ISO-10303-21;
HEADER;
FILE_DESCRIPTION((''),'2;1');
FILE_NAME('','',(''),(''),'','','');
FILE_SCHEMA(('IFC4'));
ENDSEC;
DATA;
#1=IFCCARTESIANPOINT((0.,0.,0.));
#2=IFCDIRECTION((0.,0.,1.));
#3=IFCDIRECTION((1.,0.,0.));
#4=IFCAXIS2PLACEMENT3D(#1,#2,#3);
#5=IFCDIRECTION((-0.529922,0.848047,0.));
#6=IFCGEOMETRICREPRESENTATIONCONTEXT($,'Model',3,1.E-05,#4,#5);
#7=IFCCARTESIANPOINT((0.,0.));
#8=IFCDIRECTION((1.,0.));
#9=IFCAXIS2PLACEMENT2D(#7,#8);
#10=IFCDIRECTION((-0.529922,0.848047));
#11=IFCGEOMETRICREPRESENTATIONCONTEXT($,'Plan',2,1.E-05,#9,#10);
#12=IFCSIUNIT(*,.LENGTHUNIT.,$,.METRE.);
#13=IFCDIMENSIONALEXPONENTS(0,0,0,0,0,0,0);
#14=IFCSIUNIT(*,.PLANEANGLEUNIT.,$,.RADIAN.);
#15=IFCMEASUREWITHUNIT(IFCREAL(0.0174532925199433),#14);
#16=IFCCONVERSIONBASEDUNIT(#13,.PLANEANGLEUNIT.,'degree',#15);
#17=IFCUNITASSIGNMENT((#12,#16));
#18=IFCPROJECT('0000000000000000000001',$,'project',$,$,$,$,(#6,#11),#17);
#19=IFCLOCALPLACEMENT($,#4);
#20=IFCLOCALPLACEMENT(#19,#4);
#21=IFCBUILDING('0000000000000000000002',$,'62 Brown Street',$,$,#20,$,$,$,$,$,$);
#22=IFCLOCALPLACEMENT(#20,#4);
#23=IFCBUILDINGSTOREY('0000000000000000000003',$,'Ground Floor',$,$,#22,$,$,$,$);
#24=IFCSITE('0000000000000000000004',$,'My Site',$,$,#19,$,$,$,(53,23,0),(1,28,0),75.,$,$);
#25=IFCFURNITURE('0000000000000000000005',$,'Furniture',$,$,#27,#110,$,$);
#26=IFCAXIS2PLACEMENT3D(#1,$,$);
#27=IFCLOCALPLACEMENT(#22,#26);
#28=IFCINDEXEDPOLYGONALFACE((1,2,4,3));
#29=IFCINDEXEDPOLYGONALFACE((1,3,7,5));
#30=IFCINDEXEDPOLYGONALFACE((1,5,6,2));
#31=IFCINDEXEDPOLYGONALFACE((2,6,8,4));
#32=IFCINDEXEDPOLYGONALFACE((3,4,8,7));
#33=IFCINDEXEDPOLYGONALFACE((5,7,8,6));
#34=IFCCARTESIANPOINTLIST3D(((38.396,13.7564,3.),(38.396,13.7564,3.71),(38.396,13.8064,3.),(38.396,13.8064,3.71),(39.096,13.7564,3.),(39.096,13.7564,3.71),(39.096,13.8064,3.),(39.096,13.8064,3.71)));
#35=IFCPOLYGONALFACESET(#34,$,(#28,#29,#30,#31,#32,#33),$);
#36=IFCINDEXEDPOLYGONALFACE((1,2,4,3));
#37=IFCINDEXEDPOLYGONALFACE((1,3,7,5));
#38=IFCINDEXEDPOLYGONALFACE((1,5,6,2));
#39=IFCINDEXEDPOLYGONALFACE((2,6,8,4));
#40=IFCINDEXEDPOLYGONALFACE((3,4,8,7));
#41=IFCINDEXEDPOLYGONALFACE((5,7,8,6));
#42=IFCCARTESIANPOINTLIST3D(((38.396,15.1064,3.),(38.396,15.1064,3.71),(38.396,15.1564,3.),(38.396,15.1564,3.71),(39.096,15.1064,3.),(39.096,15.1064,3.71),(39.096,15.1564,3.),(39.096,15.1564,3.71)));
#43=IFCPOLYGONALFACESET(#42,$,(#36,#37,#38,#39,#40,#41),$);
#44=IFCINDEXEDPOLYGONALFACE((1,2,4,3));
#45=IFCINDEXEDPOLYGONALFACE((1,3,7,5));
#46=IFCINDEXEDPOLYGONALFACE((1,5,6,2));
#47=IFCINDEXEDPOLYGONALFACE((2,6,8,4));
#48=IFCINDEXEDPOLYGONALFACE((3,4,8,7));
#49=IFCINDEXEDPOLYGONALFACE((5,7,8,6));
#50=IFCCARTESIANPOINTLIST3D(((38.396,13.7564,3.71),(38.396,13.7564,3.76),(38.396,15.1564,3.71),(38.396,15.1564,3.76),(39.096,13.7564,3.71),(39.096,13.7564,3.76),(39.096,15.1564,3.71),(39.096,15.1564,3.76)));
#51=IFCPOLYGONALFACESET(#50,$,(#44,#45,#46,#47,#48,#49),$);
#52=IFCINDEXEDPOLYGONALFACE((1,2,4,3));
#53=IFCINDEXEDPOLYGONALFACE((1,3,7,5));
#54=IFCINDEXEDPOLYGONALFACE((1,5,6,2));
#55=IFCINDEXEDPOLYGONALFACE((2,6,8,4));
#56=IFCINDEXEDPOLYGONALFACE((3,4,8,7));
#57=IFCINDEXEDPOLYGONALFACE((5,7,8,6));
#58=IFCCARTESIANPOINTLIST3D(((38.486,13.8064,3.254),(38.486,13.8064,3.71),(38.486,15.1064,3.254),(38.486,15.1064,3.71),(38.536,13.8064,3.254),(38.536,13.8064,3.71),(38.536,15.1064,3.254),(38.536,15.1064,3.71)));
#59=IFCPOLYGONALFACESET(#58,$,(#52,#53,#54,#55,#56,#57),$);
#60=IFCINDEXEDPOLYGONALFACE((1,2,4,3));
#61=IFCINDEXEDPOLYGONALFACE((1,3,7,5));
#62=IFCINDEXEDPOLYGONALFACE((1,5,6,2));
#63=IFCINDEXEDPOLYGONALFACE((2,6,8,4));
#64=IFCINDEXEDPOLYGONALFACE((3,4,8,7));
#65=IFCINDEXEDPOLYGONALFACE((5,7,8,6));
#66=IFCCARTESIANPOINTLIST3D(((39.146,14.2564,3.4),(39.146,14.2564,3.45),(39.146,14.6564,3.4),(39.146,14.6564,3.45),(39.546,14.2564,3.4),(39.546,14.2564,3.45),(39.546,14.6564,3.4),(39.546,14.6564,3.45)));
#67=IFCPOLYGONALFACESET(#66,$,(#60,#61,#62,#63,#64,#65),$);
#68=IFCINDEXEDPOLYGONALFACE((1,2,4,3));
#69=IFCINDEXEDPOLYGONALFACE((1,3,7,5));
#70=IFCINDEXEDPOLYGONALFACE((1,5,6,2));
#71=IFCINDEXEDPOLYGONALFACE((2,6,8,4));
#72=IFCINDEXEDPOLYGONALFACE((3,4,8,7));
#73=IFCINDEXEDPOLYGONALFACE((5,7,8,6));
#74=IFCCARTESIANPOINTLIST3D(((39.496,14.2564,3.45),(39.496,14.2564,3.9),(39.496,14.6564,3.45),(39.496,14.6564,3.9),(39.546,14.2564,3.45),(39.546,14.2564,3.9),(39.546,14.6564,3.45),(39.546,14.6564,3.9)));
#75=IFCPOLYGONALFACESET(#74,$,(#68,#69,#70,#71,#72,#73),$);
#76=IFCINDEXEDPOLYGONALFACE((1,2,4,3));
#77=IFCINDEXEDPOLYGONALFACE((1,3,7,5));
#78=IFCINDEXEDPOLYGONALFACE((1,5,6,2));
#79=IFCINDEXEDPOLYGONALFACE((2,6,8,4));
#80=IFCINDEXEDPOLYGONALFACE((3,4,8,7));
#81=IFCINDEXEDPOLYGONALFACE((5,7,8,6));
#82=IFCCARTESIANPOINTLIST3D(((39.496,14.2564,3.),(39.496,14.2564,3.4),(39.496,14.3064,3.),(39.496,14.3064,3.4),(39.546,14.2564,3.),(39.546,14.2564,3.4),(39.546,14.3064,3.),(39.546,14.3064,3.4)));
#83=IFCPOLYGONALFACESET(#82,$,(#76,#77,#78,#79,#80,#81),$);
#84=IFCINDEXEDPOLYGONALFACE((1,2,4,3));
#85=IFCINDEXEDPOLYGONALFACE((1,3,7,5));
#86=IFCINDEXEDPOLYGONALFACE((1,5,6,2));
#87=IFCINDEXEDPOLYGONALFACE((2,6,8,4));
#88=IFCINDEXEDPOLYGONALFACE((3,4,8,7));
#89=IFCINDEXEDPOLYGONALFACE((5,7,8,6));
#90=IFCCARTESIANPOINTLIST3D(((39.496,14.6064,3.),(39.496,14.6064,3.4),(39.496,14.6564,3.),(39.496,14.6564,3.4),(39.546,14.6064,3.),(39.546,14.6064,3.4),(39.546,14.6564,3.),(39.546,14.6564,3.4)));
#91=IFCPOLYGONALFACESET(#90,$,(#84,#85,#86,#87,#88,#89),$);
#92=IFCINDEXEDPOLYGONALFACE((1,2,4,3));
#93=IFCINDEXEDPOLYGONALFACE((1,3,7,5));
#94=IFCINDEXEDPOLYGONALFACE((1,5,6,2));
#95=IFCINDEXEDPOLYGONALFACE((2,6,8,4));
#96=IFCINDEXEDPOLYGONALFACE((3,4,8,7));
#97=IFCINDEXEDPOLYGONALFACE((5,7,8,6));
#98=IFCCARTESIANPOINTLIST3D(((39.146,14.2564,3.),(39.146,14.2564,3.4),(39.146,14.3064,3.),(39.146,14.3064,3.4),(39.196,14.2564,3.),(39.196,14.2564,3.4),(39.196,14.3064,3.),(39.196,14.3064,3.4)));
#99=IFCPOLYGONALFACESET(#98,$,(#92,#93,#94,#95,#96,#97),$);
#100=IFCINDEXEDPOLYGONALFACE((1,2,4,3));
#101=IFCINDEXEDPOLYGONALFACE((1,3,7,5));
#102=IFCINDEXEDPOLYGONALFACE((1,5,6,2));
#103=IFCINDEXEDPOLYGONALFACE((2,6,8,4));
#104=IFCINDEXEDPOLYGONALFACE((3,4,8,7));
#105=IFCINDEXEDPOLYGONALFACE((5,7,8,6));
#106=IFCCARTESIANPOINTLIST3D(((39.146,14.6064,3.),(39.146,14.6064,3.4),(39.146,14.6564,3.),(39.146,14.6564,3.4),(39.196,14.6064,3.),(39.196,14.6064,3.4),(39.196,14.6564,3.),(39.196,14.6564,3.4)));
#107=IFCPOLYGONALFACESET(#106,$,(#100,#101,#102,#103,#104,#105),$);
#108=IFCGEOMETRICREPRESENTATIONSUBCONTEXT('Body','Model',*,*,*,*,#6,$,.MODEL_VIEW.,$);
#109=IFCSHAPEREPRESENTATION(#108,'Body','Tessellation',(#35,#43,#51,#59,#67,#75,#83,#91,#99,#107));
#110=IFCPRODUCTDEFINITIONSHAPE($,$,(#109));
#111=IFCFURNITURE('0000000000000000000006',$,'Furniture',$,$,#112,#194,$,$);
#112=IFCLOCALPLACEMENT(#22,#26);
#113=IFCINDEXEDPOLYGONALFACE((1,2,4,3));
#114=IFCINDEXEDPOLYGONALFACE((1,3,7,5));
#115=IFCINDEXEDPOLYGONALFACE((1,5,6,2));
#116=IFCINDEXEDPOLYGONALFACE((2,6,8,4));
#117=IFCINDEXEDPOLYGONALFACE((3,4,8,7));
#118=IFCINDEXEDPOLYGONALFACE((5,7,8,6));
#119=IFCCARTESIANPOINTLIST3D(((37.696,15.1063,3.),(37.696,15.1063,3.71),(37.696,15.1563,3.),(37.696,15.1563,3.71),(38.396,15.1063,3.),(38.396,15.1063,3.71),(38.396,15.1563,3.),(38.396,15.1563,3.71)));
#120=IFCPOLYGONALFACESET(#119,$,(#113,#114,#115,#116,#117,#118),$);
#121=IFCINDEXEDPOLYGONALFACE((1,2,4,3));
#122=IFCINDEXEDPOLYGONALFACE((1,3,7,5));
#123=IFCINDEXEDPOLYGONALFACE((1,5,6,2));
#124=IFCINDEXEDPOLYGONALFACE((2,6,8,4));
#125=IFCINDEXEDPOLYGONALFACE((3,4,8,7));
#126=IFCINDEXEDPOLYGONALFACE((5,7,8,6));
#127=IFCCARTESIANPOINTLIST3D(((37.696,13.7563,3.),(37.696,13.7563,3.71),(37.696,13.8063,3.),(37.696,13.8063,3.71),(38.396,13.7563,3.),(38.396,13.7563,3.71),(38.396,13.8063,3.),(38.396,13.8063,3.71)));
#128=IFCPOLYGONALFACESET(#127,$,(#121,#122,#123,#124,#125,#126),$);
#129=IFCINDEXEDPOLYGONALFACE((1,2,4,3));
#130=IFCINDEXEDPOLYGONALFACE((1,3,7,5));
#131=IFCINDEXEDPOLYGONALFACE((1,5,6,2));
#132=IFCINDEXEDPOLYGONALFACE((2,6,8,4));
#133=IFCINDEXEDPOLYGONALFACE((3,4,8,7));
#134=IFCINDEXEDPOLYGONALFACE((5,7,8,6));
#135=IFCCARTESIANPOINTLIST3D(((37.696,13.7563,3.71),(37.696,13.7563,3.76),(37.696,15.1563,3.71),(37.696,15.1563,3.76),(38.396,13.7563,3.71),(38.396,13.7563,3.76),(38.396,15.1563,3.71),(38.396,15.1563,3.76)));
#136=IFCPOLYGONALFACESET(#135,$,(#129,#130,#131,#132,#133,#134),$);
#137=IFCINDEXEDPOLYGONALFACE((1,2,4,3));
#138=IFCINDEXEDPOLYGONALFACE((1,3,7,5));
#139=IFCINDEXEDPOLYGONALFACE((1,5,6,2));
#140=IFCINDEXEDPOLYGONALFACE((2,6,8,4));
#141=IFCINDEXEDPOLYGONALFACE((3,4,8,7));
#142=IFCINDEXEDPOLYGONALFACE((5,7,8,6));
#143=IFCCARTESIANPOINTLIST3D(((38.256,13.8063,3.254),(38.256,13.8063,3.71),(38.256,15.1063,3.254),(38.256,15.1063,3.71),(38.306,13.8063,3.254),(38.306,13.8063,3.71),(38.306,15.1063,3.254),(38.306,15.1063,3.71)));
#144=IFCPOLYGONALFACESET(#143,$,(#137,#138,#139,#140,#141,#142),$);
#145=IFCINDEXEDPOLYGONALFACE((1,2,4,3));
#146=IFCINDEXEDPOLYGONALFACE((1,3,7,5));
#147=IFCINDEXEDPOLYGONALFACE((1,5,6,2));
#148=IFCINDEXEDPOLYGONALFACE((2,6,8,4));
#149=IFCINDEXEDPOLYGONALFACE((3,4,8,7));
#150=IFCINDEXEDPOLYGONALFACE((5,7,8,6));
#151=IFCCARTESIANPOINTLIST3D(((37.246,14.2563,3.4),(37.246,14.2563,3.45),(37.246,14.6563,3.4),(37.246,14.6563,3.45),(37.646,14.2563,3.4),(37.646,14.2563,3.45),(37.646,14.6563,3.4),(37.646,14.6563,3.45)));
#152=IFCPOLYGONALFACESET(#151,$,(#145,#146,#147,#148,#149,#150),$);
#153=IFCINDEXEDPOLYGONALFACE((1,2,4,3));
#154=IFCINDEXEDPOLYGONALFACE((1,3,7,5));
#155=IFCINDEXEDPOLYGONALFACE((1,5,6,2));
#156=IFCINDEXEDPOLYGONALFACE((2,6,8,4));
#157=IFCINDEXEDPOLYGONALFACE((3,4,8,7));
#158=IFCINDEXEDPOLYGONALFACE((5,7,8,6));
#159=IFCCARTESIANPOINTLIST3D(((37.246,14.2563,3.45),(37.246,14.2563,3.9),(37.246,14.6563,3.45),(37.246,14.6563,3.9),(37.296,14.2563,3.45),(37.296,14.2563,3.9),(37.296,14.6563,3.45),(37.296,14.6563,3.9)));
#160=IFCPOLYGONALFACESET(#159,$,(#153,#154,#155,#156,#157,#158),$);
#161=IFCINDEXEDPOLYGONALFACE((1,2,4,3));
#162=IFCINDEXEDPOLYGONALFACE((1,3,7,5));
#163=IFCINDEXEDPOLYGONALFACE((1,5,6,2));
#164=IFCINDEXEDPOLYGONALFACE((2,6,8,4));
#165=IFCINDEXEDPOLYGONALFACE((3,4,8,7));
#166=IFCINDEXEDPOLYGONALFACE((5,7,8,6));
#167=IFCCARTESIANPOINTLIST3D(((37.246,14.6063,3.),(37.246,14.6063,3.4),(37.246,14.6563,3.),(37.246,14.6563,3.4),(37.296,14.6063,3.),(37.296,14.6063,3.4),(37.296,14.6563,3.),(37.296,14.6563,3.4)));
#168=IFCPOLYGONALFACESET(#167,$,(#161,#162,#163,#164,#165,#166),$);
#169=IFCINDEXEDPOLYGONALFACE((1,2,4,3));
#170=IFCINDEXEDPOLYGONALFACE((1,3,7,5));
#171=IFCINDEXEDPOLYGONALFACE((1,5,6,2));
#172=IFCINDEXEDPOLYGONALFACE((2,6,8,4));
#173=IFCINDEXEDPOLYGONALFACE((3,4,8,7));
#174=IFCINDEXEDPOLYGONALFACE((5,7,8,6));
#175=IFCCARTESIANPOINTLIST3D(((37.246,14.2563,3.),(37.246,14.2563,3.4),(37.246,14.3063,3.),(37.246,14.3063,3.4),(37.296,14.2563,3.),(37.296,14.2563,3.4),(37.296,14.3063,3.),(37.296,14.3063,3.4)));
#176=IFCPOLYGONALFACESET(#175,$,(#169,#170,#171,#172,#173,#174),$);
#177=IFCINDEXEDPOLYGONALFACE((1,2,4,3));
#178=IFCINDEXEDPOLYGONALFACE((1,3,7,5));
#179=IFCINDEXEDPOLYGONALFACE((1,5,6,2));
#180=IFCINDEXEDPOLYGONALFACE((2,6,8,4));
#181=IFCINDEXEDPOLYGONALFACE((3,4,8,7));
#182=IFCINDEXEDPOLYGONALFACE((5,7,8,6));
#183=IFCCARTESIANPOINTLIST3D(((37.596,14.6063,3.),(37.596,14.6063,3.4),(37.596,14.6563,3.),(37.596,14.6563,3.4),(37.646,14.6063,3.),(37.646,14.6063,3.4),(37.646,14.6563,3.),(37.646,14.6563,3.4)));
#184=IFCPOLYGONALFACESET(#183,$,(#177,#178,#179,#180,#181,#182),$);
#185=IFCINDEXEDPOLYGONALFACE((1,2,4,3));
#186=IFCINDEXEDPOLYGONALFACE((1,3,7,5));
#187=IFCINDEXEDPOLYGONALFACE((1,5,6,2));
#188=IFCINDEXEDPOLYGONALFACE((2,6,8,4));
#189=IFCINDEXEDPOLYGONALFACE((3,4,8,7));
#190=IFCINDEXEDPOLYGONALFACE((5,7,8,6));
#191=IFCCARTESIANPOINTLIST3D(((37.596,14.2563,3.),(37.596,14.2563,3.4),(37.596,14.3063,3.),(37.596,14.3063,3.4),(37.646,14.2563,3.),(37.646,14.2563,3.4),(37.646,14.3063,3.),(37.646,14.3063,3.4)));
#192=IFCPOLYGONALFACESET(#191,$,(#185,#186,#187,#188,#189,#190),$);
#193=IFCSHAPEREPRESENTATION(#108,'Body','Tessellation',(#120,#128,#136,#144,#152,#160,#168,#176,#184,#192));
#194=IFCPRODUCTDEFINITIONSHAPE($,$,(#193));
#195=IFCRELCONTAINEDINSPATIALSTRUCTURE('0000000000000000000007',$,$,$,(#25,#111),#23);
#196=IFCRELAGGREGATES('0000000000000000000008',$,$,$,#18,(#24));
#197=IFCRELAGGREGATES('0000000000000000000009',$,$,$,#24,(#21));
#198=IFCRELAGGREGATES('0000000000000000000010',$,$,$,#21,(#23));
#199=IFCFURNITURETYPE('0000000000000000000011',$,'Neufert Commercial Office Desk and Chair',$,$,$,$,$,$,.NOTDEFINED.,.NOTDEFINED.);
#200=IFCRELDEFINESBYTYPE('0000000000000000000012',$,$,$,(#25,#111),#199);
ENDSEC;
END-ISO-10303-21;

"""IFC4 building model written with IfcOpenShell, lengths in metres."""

from ifc_helpers import new_model, entity, si_unit, converted_unit, direction, frame, origin_with_axes, origin_2d_with_axis, place, context, subcontext, project, spatial, line, indexed_curve, outline, extrude, shape, source, transform, mapped, type_object, type_shapes, element, save


model = new_model("IFC4")

# Units and contexts
model_context = context("Model", 3, precision=1e-05, world=origin_with_axes(), true_north=direction((-0.529922, 0.848047, 0.0)))
plan_context = context("Plan", 2, precision=1e-05, world=origin_2d_with_axis(), true_north=direction((-0.529922, 0.848047)))
body_context_1 = subcontext(model_context, "Body", "Model", "MODEL_VIEW")
body_context_2 = subcontext(plan_context, "Body", "Plan", "PLAN_VIEW")
ifc_project = project(units=[si_unit("LENGTHUNIT", "METRE"), converted_unit("PLANEANGLEUNIT", "degree", entity("IfcReal", 0.0174532925199433), si_unit("PLANEANGLEUNIT", "RADIAN"), dimensions=[0, 0, 0, 0, 0, 0, 0])], contexts=[model_context, plan_context])

# Site, building, storey
site_placement = place(None, origin_with_axes())
site = spatial("IfcSite", under=ifc_project, at=site_placement, Name="My Site", RefLatitude=(53, 23, 0), RefLongitude=(1, 28, 0), RefElevation=75.0)
building_placement = place(site_placement, origin_with_axes())
building = spatial("IfcBuilding", under=site, at=building_placement, Name="62 Brown Street")
storey_placement = place(building_placement, origin_with_axes())
storey = spatial("IfcBuildingStorey", under=building, at=storey_placement, Name="Ground Floor")

# Furniture
furniture_type = type_object("IfcFurnitureType", Name="Neufert Commercial Office Desk and Chair", AssemblyPlace="NOTDEFINED", PredefinedType="NOTDEFINED")
shared_shape_1 = source(origin_with_axes(), body_context_1, "Body", "SweptSolid", [
    extrude(outline(indexed_curve([(0.0, 0.0), (0.05, 0.0), (0.05, 0.7), (0.0, 0.7)], segments=[line(1, 2, 3, 4, 1)])), frame((0.0, 0.45, 0.0), z_axis=(0.0, 0.0, 1.0), x_axis=(1.0, 0.0, 0.0)), (0.0, 0.0, 1.0), 0.71),
    extrude(outline(indexed_curve([(0.0, 0.0), (0.05, 0.0), (0.05, 0.7), (0.0, 0.7)], segments=[line(1, 2, 3, 4, 1)])), frame((1.35, 0.45, 0.0), z_axis=(0.0, 0.0, 1.0), x_axis=(1.0, 0.0, 0.0)), (0.0, 0.0, 1.0), 0.71),
    extrude(outline(indexed_curve([(0.0, 0.0), (1.4, 0.0), (1.4, 0.7), (0.0, 0.7)], segments=[line(1, 2, 3, 4, 1)])), frame((0.0, 0.45, 0.71), z_axis=(0.0, 0.0, 1.0), x_axis=(1.0, 0.0, 0.0)), (0.0, 0.0, 1.0), 0.05),
    extrude(outline(indexed_curve([(0.05, 0.56), (1.35, 0.56), (1.35, 0.61), (0.05, 0.61)], segments=[line(1, 2, 3, 4, 1)])), frame((0.0, 0.45, 0.254), z_axis=(0.0, 0.0, 1.0), x_axis=(1.0, 0.0, 0.0)), (0.0, 0.0, 1.0), 0.456),
    extrude(outline(indexed_curve([(-0.2, 0.0), (0.2, 0.0), (0.2, 0.4), (-0.2, 0.4)], segments=[line(1, 2, 3, 4, 1)])), frame((0.7, 0.0, 0.45), z_axis=(0.0, 0.0, 1.0), x_axis=(1.0, 0.0, 0.0)), (0.0, 0.0, -1.0), 0.05),
    extrude(outline(indexed_curve([(-0.2, 0.0), (0.2, 0.0), (0.2, 0.05), (-0.2, 0.05)], segments=[line(1, 2, 3, 4, 1)])), frame((0.7, 0.0, 0.9), z_axis=(0.0, 0.0, 1.0), x_axis=(1.0, 0.0, 0.0)), (0.0, 0.0, -1.0), 0.45),
    extrude(outline(indexed_curve([(-0.2, 0.0), (-0.15, 0.0), (-0.15, 0.05), (-0.2, 0.05)], segments=[line(1, 2, 3, 4, 1)])), frame((0.7, 0.0, 0.0), z_axis=(0.0, 0.0, 1.0), x_axis=(1.0, 0.0, 0.0)), (0.0, 0.0, 1.0), 0.4),
    extrude(outline(indexed_curve([(0.2, 0.0), (0.15, 0.0), (0.15, 0.05), (0.2, 0.05)], segments=[line(1, 2, 3, 4, 1)])), frame((0.7, 0.0, 0.0), z_axis=(0.0, 0.0, 1.0), x_axis=(1.0, 0.0, 0.0)), (0.0, 0.0, 1.0), 0.4),
    extrude(outline(indexed_curve([(-0.2, 0.4), (-0.15, 0.4), (-0.15, 0.35), (-0.2, 0.35)], segments=[line(1, 2, 3, 4, 1)])), frame((0.7, 0.0, 0.0), z_axis=(0.0, 0.0, 1.0), x_axis=(1.0, 0.0, 0.0)), (0.0, 0.0, 1.0), 0.4),
    extrude(outline(indexed_curve([(0.2, 0.4), (0.15, 0.4), (0.15, 0.35), (0.2, 0.35)], segments=[line(1, 2, 3, 4, 1)])), frame((0.7, 0.0, 0.0), z_axis=(0.0, 0.0, 1.0), x_axis=(1.0, 0.0, 0.0)), (0.0, 0.0, 1.0), 0.4),
])
shared_shape_2 = source(origin_with_axes(), body_context_2, "Body", "Curve2D", [
    entity("IfcIndexedPolyCurve", entity("IfcCartesianPointList2D", [[0.0, 0.45], [1.4, 0.45], [1.4, 1.15], [0.0, 1.15]]), [entity("IfcLineIndex", [1, 2, 3, 4, 1])]),
    entity("IfcIndexedPolyCurve", entity("IfcCartesianPointList2D", [[0.5, 0.4], [0.9, 0.4]])),
    entity("IfcIndexedPolyCurve", entity("IfcCartesianPointList2D", [[0.5, 0.4], [0.5, 0.2], [0.5586, 0.0586], [0.7, 0.0], [0.8414, 0.0586], [0.9, 0.2], [0.9, 0.4]]), [entity("IfcLineIndex", [1, 2]), entity("IfcArcIndex", [2, 3, 4]), entity("IfcArcIndex", [4, 5, 6]), entity("IfcLineIndex", [6, 7])]),
    entity("IfcIndexedPolyCurve", entity("IfcCartesianPointList2D", [[0.54, 0.4], [0.54, 0.2], [0.5869, 0.0869], [0.7, 0.04], [0.8131, 0.0869], [0.86, 0.2], [0.86, 0.4]]), [entity("IfcLineIndex", [1, 2]), entity("IfcArcIndex", [2, 3, 4]), entity("IfcArcIndex", [4, 5, 6]), entity("IfcLineIndex", [6, 7])]),
])
type_shapes(furniture_type, [shared_shape_1, shared_shape_2])
for number, where, z_axis, x_axis, name in (
    (1, (39.546, 13.7564, 3.0), (0.0, 0.0, 1.0), (0.0, 1.0, 0.0), "Furniture"),
    (2, (37.246, 15.1563, 3.0), (0.0, 0.0, 1.0), (0.0, -1.0, 0.0), "Furniture"),
):
    element("IfcFurniture", number, at=place(storey_placement, frame(where, z_axis=z_axis, x_axis=x_axis)), inside=storey, type_object=furniture_type, Name=name, shapes=[
        shape(body_context_1, "Body", "MappedRepresentation", [mapped(shared_shape_1, transform((0.0, 0.0, 0.0), x_axis=(1.0, 0.0, 0.0), y_axis=(0.0, 1.0, 0.0), z_axis=(0.0, 0.0, 1.0), scale=1.0))]),
        shape(body_context_2, "Body", "MappedRepresentation", [mapped(shared_shape_2, transform((0.0, 0.0, 0.0), x_axis=(1.0, 0.0, 0.0), y_axis=(0.0, 1.0, 0.0), z_axis=(0.0, 0.0, 1.0), scale=1.0))]),
    ])

save(model, "model.ifc")
